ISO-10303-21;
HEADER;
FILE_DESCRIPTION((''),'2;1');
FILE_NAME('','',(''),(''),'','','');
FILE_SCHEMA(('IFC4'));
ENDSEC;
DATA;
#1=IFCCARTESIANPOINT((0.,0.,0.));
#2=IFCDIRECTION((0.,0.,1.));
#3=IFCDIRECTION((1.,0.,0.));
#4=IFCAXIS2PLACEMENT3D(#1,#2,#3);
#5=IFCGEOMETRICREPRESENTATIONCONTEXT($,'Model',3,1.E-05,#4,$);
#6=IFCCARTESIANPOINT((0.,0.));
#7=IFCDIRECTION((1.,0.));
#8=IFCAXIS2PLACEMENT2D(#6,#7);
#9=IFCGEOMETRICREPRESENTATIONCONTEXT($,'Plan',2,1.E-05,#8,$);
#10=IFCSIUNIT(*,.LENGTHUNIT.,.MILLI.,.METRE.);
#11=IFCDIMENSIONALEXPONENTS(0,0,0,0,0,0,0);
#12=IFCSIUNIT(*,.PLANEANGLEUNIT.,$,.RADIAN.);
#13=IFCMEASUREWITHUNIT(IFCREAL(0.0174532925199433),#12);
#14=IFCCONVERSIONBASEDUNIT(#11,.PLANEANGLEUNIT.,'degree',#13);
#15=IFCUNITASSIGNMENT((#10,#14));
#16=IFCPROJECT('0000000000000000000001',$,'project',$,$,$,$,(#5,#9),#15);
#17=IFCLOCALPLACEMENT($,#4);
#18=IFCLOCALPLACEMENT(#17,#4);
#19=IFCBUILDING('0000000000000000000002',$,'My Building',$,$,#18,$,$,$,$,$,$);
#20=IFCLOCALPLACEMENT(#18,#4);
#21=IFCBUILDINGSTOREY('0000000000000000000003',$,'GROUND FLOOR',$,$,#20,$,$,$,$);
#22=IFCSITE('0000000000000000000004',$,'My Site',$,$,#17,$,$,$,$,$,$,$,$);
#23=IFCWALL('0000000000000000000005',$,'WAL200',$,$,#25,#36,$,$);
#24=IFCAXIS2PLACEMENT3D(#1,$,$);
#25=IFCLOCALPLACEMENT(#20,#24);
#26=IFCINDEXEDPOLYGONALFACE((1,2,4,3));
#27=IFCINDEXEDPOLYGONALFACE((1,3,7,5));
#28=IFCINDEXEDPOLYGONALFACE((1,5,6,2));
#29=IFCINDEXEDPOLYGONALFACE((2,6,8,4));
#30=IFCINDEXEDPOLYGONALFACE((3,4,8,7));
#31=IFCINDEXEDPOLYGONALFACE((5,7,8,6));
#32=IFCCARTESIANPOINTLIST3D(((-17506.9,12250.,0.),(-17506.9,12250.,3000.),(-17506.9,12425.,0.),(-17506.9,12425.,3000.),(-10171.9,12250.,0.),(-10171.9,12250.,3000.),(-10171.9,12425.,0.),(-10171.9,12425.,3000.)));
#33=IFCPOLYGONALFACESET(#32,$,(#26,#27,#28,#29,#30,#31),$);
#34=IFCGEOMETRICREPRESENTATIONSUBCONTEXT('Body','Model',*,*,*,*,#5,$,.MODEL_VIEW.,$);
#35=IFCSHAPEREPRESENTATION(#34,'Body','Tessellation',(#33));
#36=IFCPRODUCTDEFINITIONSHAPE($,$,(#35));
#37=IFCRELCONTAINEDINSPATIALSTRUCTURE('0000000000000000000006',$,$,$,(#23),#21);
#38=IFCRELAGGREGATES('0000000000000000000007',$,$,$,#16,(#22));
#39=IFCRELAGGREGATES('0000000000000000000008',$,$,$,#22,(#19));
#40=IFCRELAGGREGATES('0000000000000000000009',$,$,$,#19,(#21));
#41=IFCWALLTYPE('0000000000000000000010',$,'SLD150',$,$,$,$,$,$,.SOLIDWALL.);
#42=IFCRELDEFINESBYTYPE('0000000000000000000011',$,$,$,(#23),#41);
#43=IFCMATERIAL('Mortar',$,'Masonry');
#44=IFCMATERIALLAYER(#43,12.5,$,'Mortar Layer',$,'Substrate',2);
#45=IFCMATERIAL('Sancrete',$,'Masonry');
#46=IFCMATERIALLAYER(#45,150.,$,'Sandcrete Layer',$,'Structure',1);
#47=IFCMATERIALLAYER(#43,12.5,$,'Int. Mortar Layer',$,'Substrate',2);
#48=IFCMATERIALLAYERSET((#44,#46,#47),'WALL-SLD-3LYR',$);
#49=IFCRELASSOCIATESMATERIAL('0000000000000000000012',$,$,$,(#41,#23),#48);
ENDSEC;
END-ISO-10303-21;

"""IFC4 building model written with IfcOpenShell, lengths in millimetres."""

from ifc_helpers import new_model, entity, si_unit, converted_unit, frame, origin_with_axes, origin_2d_with_axis, place, context, subcontext, project, spatial, indexed_curve, outline, extrude, material, layer, layer_set, layer_usage, type_object, element, save


model = new_model("IFC4")

# Units and contexts
model_context = context("Model", 3, precision=1e-05, world=origin_with_axes())
plan_context = context("Plan", 2, precision=1e-05, world=origin_2d_with_axis())
body_context_1 = subcontext(model_context, "Body", "Model", "MODEL_VIEW")
ifc_project = project(units=[si_unit("LENGTHUNIT", "METRE", prefix="MILLI"), converted_unit("PLANEANGLEUNIT", "degree", entity("IfcReal", 0.0174532925199433), si_unit("PLANEANGLEUNIT", "RADIAN"), dimensions=[0, 0, 0, 0, 0, 0, 0])], contexts=[model_context, plan_context])

# Site, building, storey
site_placement = place(None, origin_with_axes())
site = spatial("IfcSite", under=ifc_project, at=site_placement, Name="My Site")
building_placement = place(site_placement, origin_with_axes())
building = spatial("IfcBuilding", under=site, at=building_placement, Name="My Building")
storey_placement = place(building_placement, origin_with_axes())
storey = spatial("IfcBuildingStorey", under=building, at=storey_placement, Name="GROUND FLOOR")

# Shared definitions
ifc_material_1 = material(Name="Mortar", Category="Masonry")
ifc_layer_1 = layer(ifc_material_1, 12.5, Name="Mortar Layer", Category="Substrate", Priority=2)
ifc_material_2 = material(Name="Sancrete", Category="Masonry")
ifc_layer_2 = layer(ifc_material_2, 150.0, Name="Sandcrete Layer", Category="Structure", Priority=1)
ifc_layer_3 = layer(ifc_material_1, 12.5, Name="Int. Mortar Layer", Category="Substrate", Priority=2)
ifc_layer_set_1 = layer_set([ifc_layer_1, ifc_layer_2, ifc_layer_3], Name="WALL-SLD-3LYR")
wall_type_1 = type_object("IfcWallType", Name="SLD150", PredefinedType="SOLIDWALL", material=ifc_layer_set_1)

# Wall
ifc_layer_usage_1 = layer_usage(ifc_layer_set_1, "AXIS2", "POSITIVE", 0.0)
wall_1_placement = place(storey_placement, frame((-10171.9, 12425.0, 0.0), z_axis=(0.0, 0.0, 1.0), x_axis=(-1.0, 0.0, 0.0)))
element("IfcWall", 1, at=wall_1_placement, inside=storey, type_object=wall_type_1, material=ifc_layer_usage_1, Name="WAL200", context=body_context_1, shape_type="SweptSolid", body=[
    extrude(outline(indexed_curve([(0.0, 0.0), (0.0, 175.0), (7335.0, 175.0), (7335.0, 0.0), (0.0, 0.0)], self_intersect=False)), origin_with_axes(), (0.0, 0.0, 1.0), 3000.0),
])

save(model, "model.ifc")
